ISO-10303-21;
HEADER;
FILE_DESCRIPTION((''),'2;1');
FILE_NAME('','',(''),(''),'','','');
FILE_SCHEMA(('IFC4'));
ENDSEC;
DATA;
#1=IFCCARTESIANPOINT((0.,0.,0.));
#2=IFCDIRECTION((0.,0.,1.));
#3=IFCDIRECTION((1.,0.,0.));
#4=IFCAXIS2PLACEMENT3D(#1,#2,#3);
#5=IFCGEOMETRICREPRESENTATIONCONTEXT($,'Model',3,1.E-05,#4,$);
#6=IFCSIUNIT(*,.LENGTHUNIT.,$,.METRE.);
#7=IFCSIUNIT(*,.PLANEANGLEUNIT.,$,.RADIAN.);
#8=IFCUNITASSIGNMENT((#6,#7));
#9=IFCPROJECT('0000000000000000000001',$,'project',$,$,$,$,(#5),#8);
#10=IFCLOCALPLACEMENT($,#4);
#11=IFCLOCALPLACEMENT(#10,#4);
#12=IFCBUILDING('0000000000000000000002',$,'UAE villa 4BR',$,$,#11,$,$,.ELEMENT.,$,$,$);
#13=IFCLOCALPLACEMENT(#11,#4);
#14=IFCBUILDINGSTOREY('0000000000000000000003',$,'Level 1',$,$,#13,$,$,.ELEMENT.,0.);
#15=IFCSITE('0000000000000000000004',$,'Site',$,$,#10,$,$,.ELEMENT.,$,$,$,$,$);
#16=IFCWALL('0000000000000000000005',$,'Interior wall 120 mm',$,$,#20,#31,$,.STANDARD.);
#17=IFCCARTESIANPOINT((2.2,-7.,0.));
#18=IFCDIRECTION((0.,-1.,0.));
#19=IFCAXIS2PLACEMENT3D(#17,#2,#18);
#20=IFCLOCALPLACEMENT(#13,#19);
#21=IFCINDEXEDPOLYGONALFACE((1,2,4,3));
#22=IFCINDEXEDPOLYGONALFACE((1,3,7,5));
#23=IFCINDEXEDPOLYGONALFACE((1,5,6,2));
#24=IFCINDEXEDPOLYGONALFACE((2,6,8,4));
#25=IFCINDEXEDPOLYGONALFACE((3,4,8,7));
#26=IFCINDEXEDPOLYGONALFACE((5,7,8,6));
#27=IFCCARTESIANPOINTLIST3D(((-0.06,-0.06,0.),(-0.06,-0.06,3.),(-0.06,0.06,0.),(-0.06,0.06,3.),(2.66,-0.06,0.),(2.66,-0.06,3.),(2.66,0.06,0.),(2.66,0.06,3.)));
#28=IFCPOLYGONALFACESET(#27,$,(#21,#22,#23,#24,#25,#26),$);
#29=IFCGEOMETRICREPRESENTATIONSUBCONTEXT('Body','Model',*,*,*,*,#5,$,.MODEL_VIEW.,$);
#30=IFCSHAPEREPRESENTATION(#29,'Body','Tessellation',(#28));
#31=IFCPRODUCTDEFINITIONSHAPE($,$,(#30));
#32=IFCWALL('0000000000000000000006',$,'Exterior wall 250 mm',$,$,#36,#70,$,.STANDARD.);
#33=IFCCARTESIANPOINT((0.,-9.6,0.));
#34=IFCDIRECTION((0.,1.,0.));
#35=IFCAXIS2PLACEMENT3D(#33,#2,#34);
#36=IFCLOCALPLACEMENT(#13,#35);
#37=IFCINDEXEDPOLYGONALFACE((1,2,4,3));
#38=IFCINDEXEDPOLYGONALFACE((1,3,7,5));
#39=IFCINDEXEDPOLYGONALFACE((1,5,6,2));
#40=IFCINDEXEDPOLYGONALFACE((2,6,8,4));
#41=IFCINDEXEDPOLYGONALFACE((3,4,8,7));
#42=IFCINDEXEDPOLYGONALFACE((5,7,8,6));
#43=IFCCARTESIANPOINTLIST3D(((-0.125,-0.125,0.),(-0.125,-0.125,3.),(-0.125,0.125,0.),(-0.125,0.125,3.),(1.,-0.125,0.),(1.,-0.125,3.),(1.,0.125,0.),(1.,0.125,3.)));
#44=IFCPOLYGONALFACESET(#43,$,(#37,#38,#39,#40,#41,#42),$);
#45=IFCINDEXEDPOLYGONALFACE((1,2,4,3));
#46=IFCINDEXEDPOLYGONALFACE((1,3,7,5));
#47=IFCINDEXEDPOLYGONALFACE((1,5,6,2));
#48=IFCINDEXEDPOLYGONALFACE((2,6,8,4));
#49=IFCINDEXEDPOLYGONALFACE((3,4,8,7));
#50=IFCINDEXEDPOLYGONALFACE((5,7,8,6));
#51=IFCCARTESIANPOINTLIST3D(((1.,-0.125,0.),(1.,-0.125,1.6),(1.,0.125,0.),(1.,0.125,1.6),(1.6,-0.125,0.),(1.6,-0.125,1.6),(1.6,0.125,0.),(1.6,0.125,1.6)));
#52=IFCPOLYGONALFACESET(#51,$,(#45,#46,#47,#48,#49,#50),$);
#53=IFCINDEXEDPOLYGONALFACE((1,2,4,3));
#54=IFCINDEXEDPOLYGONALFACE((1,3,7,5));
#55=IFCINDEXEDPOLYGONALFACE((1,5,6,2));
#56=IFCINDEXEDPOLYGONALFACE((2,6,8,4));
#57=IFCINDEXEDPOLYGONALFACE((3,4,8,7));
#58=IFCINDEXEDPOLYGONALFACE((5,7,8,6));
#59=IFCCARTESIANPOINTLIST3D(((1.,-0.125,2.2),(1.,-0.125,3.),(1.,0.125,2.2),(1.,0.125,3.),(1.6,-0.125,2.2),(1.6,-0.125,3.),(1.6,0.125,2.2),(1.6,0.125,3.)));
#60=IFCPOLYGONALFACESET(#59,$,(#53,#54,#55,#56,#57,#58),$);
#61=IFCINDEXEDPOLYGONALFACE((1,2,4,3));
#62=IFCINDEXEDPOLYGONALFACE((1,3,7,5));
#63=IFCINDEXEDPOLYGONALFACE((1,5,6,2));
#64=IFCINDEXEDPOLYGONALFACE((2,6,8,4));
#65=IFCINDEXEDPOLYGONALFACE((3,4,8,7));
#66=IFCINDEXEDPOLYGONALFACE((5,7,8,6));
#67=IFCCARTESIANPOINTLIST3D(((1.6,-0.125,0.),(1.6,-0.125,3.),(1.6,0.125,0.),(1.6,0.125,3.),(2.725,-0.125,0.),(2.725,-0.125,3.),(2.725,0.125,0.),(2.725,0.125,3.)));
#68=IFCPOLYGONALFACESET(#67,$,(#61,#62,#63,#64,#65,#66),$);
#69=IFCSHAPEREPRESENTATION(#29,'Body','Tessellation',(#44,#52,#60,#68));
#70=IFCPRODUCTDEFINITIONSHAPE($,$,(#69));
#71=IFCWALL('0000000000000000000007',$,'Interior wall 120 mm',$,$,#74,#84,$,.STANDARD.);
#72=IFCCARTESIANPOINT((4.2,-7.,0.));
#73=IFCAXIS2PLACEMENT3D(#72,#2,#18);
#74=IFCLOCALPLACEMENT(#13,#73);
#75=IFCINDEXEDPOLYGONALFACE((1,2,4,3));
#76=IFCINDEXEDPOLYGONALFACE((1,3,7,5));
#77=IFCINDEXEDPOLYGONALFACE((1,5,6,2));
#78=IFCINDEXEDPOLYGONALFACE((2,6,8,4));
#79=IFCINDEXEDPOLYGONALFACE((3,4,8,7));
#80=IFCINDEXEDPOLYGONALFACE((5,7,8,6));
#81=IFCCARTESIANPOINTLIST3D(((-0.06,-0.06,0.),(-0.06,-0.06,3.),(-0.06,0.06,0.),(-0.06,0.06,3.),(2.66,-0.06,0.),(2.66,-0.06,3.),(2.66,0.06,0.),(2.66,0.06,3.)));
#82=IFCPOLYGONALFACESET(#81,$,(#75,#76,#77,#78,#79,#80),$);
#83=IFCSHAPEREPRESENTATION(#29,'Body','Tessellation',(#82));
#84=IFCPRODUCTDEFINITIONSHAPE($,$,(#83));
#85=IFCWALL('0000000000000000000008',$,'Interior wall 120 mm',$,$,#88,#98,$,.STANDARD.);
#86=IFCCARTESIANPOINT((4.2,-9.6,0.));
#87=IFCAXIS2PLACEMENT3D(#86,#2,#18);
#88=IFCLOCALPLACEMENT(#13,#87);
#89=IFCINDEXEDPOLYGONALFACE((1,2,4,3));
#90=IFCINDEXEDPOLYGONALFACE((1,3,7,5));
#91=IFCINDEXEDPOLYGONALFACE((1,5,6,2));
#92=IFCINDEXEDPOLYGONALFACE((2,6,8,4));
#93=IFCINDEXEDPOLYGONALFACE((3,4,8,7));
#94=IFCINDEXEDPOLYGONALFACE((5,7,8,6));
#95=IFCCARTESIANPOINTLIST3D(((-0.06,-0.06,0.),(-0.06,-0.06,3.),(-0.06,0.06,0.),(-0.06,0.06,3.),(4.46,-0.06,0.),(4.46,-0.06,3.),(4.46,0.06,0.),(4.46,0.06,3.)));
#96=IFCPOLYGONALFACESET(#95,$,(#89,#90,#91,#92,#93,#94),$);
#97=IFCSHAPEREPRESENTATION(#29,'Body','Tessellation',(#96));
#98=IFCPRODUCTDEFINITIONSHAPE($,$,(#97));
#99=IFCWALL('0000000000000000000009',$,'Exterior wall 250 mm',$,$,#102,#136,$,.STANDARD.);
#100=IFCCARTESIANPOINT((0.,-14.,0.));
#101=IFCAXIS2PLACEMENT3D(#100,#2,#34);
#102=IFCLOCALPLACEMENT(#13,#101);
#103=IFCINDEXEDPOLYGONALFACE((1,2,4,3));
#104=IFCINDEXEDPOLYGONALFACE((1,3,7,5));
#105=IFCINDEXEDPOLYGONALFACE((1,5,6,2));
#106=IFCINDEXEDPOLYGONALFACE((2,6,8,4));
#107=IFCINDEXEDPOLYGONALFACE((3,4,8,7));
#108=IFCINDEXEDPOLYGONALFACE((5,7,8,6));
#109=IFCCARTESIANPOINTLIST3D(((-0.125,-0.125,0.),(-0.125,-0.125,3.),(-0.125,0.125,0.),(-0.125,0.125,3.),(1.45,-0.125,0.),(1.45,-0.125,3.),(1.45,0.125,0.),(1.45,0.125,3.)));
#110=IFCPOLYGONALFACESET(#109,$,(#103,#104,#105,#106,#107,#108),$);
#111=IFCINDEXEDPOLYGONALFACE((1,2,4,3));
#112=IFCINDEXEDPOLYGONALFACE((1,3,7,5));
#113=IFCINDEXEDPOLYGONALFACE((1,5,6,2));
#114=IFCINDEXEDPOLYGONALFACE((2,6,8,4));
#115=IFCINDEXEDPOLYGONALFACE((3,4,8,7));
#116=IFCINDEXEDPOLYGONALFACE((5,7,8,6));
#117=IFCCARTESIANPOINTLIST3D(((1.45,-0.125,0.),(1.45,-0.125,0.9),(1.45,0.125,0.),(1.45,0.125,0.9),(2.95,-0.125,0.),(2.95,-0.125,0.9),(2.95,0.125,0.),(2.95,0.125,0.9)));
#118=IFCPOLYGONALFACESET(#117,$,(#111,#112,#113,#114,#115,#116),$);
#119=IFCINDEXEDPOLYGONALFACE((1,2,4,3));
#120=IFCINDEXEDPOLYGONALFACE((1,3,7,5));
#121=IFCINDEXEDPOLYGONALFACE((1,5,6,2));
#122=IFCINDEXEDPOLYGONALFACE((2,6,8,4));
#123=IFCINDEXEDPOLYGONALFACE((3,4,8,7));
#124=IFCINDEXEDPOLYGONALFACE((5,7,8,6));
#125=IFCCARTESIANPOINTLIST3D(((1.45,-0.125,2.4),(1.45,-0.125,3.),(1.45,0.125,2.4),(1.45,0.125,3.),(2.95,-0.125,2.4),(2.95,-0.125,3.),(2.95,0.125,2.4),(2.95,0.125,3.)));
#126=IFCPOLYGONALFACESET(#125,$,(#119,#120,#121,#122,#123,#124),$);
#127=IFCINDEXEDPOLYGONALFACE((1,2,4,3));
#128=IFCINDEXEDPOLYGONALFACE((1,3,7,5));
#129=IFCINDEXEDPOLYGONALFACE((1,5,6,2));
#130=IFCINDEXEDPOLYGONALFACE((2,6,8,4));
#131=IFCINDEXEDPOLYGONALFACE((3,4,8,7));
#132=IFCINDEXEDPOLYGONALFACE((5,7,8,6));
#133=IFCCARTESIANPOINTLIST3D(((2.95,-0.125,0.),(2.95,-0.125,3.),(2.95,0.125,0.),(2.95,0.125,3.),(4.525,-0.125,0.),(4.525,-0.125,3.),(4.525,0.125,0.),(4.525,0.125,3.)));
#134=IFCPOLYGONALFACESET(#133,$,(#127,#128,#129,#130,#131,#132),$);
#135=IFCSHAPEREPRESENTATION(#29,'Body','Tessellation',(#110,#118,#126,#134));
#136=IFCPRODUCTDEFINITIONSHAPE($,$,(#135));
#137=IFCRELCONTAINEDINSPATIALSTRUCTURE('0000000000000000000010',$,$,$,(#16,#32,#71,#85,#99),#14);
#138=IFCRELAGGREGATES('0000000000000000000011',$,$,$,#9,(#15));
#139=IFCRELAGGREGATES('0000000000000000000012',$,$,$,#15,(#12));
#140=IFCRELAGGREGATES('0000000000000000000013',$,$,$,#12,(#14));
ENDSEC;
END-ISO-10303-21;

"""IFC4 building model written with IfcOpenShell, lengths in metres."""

from ifc_helpers import new_model, si_unit, frame, origin_with_axes, origin_2d, place, context, subcontext, project, spatial, rectangle, extrude, element, save


model = new_model("IFC4")

# Units and contexts
model_context = context("Model", 3, precision=1e-05, world=origin_with_axes())
body_context = subcontext(model_context, "Body", "Model", "MODEL_VIEW")
ifc_project = project(units=[si_unit("LENGTHUNIT", "METRE"), si_unit("PLANEANGLEUNIT", "RADIAN")], contexts=[model_context])

# Site, building, storey
site_placement = place(None, origin_with_axes())
site = spatial("IfcSite", under=ifc_project, at=site_placement, Name="Site", CompositionType="ELEMENT")
building_placement = place(site_placement, origin_with_axes())
building = spatial("IfcBuilding", under=site, at=building_placement, Name="UAE villa 4BR", CompositionType="ELEMENT")
storey_placement = place(building_placement, origin_with_axes())
storey = spatial("IfcBuildingStorey", under=building, at=storey_placement, Name="Level 1", CompositionType="ELEMENT", Elevation=0.0)

# Walls
wall_1_placement = place(storey_placement, frame((2.2, -7.0, 0.0), z_axis=(0.0, 0.0, 1.0), x_axis=(0.0, -1.0, 0.0)))
element("IfcWall", 1, at=wall_1_placement, inside=storey, Name="Interior wall 120 mm", PredefinedType="STANDARD", context=body_context, shape_type="SweptSolid", body=[
    extrude(rectangle(XDim=2.72, YDim=0.12, at=origin_2d()), frame((1.3, 0.0, 0.0)), (0.0, 0.0, 1.0), 3.0),
])
wall_2_placement = place(storey_placement, frame((0.0, -9.6, 0.0), z_axis=(0.0, 0.0, 1.0), x_axis=(0.0, 1.0, 0.0)))
element("IfcWall", 2, at=wall_2_placement, inside=storey, Name="Exterior wall 250 mm", PredefinedType="STANDARD", context=body_context, shape_type="SweptSolid", body=[
    extrude(rectangle(XDim=1.125, YDim=0.25, at=origin_2d()), frame((0.4375, 0.0, 0.0)), (0.0, 0.0, 1.0), 3.0),
    extrude(rectangle(XDim=0.6, YDim=0.25, at=origin_2d()), frame((1.3, 0.0, 0.0)), (0.0, 0.0, 1.0), 1.6),
    extrude(rectangle(XDim=0.6, YDim=0.25, at=origin_2d()), frame((1.3, 0.0, 2.2)), (0.0, 0.0, 1.0), 0.8),
    extrude(rectangle(XDim=1.125, YDim=0.25, at=origin_2d()), frame((2.1625, 0.0, 0.0)), (0.0, 0.0, 1.0), 3.0),
])
wall_3_placement = place(storey_placement, frame((4.2, -7.0, 0.0), z_axis=(0.0, 0.0, 1.0), x_axis=(0.0, -1.0, 0.0)))
element("IfcWall", 3, at=wall_3_placement, inside=storey, Name="Interior wall 120 mm", PredefinedType="STANDARD", context=body_context, shape_type="SweptSolid", body=[
    extrude(rectangle(XDim=2.72, YDim=0.12, at=origin_2d()), frame((1.3, 0.0, 0.0)), (0.0, 0.0, 1.0), 3.0),
])
wall_4_placement = place(storey_placement, frame((4.2, -9.6, 0.0), z_axis=(0.0, 0.0, 1.0), x_axis=(0.0, -1.0, 0.0)))
element("IfcWall", 4, at=wall_4_placement, inside=storey, Name="Interior wall 120 mm", PredefinedType="STANDARD", context=body_context, shape_type="SweptSolid", body=[
    extrude(rectangle(XDim=4.52, YDim=0.12, at=origin_2d()), frame((2.2, 0.0, 0.0)), (0.0, 0.0, 1.0), 3.0),
])
wall_5_placement = place(storey_placement, frame((0.0, -14.0, 0.0), z_axis=(0.0, 0.0, 1.0), x_axis=(0.0, 1.0, 0.0)))
element("IfcWall", 5, at=wall_5_placement, inside=storey, Name="Exterior wall 250 mm", PredefinedType="STANDARD", context=body_context, shape_type="SweptSolid", body=[
    extrude(rectangle(XDim=1.575, YDim=0.25, at=origin_2d()), frame((0.6625, 0.0, 0.0)), (0.0, 0.0, 1.0), 3.0),
    extrude(rectangle(XDim=1.5, YDim=0.25, at=origin_2d()), frame((2.2, 0.0, 0.0)), (0.0, 0.0, 1.0), 0.9),
    extrude(rectangle(XDim=1.5, YDim=0.25, at=origin_2d()), frame((2.2, 0.0, 2.4)), (0.0, 0.0, 1.0), 0.6),
    extrude(rectangle(XDim=1.575, YDim=0.25, at=origin_2d()), frame((3.7375, 0.0, 0.0)), (0.0, 0.0, 1.0), 3.0),
])

save(model, "model.ifc")
